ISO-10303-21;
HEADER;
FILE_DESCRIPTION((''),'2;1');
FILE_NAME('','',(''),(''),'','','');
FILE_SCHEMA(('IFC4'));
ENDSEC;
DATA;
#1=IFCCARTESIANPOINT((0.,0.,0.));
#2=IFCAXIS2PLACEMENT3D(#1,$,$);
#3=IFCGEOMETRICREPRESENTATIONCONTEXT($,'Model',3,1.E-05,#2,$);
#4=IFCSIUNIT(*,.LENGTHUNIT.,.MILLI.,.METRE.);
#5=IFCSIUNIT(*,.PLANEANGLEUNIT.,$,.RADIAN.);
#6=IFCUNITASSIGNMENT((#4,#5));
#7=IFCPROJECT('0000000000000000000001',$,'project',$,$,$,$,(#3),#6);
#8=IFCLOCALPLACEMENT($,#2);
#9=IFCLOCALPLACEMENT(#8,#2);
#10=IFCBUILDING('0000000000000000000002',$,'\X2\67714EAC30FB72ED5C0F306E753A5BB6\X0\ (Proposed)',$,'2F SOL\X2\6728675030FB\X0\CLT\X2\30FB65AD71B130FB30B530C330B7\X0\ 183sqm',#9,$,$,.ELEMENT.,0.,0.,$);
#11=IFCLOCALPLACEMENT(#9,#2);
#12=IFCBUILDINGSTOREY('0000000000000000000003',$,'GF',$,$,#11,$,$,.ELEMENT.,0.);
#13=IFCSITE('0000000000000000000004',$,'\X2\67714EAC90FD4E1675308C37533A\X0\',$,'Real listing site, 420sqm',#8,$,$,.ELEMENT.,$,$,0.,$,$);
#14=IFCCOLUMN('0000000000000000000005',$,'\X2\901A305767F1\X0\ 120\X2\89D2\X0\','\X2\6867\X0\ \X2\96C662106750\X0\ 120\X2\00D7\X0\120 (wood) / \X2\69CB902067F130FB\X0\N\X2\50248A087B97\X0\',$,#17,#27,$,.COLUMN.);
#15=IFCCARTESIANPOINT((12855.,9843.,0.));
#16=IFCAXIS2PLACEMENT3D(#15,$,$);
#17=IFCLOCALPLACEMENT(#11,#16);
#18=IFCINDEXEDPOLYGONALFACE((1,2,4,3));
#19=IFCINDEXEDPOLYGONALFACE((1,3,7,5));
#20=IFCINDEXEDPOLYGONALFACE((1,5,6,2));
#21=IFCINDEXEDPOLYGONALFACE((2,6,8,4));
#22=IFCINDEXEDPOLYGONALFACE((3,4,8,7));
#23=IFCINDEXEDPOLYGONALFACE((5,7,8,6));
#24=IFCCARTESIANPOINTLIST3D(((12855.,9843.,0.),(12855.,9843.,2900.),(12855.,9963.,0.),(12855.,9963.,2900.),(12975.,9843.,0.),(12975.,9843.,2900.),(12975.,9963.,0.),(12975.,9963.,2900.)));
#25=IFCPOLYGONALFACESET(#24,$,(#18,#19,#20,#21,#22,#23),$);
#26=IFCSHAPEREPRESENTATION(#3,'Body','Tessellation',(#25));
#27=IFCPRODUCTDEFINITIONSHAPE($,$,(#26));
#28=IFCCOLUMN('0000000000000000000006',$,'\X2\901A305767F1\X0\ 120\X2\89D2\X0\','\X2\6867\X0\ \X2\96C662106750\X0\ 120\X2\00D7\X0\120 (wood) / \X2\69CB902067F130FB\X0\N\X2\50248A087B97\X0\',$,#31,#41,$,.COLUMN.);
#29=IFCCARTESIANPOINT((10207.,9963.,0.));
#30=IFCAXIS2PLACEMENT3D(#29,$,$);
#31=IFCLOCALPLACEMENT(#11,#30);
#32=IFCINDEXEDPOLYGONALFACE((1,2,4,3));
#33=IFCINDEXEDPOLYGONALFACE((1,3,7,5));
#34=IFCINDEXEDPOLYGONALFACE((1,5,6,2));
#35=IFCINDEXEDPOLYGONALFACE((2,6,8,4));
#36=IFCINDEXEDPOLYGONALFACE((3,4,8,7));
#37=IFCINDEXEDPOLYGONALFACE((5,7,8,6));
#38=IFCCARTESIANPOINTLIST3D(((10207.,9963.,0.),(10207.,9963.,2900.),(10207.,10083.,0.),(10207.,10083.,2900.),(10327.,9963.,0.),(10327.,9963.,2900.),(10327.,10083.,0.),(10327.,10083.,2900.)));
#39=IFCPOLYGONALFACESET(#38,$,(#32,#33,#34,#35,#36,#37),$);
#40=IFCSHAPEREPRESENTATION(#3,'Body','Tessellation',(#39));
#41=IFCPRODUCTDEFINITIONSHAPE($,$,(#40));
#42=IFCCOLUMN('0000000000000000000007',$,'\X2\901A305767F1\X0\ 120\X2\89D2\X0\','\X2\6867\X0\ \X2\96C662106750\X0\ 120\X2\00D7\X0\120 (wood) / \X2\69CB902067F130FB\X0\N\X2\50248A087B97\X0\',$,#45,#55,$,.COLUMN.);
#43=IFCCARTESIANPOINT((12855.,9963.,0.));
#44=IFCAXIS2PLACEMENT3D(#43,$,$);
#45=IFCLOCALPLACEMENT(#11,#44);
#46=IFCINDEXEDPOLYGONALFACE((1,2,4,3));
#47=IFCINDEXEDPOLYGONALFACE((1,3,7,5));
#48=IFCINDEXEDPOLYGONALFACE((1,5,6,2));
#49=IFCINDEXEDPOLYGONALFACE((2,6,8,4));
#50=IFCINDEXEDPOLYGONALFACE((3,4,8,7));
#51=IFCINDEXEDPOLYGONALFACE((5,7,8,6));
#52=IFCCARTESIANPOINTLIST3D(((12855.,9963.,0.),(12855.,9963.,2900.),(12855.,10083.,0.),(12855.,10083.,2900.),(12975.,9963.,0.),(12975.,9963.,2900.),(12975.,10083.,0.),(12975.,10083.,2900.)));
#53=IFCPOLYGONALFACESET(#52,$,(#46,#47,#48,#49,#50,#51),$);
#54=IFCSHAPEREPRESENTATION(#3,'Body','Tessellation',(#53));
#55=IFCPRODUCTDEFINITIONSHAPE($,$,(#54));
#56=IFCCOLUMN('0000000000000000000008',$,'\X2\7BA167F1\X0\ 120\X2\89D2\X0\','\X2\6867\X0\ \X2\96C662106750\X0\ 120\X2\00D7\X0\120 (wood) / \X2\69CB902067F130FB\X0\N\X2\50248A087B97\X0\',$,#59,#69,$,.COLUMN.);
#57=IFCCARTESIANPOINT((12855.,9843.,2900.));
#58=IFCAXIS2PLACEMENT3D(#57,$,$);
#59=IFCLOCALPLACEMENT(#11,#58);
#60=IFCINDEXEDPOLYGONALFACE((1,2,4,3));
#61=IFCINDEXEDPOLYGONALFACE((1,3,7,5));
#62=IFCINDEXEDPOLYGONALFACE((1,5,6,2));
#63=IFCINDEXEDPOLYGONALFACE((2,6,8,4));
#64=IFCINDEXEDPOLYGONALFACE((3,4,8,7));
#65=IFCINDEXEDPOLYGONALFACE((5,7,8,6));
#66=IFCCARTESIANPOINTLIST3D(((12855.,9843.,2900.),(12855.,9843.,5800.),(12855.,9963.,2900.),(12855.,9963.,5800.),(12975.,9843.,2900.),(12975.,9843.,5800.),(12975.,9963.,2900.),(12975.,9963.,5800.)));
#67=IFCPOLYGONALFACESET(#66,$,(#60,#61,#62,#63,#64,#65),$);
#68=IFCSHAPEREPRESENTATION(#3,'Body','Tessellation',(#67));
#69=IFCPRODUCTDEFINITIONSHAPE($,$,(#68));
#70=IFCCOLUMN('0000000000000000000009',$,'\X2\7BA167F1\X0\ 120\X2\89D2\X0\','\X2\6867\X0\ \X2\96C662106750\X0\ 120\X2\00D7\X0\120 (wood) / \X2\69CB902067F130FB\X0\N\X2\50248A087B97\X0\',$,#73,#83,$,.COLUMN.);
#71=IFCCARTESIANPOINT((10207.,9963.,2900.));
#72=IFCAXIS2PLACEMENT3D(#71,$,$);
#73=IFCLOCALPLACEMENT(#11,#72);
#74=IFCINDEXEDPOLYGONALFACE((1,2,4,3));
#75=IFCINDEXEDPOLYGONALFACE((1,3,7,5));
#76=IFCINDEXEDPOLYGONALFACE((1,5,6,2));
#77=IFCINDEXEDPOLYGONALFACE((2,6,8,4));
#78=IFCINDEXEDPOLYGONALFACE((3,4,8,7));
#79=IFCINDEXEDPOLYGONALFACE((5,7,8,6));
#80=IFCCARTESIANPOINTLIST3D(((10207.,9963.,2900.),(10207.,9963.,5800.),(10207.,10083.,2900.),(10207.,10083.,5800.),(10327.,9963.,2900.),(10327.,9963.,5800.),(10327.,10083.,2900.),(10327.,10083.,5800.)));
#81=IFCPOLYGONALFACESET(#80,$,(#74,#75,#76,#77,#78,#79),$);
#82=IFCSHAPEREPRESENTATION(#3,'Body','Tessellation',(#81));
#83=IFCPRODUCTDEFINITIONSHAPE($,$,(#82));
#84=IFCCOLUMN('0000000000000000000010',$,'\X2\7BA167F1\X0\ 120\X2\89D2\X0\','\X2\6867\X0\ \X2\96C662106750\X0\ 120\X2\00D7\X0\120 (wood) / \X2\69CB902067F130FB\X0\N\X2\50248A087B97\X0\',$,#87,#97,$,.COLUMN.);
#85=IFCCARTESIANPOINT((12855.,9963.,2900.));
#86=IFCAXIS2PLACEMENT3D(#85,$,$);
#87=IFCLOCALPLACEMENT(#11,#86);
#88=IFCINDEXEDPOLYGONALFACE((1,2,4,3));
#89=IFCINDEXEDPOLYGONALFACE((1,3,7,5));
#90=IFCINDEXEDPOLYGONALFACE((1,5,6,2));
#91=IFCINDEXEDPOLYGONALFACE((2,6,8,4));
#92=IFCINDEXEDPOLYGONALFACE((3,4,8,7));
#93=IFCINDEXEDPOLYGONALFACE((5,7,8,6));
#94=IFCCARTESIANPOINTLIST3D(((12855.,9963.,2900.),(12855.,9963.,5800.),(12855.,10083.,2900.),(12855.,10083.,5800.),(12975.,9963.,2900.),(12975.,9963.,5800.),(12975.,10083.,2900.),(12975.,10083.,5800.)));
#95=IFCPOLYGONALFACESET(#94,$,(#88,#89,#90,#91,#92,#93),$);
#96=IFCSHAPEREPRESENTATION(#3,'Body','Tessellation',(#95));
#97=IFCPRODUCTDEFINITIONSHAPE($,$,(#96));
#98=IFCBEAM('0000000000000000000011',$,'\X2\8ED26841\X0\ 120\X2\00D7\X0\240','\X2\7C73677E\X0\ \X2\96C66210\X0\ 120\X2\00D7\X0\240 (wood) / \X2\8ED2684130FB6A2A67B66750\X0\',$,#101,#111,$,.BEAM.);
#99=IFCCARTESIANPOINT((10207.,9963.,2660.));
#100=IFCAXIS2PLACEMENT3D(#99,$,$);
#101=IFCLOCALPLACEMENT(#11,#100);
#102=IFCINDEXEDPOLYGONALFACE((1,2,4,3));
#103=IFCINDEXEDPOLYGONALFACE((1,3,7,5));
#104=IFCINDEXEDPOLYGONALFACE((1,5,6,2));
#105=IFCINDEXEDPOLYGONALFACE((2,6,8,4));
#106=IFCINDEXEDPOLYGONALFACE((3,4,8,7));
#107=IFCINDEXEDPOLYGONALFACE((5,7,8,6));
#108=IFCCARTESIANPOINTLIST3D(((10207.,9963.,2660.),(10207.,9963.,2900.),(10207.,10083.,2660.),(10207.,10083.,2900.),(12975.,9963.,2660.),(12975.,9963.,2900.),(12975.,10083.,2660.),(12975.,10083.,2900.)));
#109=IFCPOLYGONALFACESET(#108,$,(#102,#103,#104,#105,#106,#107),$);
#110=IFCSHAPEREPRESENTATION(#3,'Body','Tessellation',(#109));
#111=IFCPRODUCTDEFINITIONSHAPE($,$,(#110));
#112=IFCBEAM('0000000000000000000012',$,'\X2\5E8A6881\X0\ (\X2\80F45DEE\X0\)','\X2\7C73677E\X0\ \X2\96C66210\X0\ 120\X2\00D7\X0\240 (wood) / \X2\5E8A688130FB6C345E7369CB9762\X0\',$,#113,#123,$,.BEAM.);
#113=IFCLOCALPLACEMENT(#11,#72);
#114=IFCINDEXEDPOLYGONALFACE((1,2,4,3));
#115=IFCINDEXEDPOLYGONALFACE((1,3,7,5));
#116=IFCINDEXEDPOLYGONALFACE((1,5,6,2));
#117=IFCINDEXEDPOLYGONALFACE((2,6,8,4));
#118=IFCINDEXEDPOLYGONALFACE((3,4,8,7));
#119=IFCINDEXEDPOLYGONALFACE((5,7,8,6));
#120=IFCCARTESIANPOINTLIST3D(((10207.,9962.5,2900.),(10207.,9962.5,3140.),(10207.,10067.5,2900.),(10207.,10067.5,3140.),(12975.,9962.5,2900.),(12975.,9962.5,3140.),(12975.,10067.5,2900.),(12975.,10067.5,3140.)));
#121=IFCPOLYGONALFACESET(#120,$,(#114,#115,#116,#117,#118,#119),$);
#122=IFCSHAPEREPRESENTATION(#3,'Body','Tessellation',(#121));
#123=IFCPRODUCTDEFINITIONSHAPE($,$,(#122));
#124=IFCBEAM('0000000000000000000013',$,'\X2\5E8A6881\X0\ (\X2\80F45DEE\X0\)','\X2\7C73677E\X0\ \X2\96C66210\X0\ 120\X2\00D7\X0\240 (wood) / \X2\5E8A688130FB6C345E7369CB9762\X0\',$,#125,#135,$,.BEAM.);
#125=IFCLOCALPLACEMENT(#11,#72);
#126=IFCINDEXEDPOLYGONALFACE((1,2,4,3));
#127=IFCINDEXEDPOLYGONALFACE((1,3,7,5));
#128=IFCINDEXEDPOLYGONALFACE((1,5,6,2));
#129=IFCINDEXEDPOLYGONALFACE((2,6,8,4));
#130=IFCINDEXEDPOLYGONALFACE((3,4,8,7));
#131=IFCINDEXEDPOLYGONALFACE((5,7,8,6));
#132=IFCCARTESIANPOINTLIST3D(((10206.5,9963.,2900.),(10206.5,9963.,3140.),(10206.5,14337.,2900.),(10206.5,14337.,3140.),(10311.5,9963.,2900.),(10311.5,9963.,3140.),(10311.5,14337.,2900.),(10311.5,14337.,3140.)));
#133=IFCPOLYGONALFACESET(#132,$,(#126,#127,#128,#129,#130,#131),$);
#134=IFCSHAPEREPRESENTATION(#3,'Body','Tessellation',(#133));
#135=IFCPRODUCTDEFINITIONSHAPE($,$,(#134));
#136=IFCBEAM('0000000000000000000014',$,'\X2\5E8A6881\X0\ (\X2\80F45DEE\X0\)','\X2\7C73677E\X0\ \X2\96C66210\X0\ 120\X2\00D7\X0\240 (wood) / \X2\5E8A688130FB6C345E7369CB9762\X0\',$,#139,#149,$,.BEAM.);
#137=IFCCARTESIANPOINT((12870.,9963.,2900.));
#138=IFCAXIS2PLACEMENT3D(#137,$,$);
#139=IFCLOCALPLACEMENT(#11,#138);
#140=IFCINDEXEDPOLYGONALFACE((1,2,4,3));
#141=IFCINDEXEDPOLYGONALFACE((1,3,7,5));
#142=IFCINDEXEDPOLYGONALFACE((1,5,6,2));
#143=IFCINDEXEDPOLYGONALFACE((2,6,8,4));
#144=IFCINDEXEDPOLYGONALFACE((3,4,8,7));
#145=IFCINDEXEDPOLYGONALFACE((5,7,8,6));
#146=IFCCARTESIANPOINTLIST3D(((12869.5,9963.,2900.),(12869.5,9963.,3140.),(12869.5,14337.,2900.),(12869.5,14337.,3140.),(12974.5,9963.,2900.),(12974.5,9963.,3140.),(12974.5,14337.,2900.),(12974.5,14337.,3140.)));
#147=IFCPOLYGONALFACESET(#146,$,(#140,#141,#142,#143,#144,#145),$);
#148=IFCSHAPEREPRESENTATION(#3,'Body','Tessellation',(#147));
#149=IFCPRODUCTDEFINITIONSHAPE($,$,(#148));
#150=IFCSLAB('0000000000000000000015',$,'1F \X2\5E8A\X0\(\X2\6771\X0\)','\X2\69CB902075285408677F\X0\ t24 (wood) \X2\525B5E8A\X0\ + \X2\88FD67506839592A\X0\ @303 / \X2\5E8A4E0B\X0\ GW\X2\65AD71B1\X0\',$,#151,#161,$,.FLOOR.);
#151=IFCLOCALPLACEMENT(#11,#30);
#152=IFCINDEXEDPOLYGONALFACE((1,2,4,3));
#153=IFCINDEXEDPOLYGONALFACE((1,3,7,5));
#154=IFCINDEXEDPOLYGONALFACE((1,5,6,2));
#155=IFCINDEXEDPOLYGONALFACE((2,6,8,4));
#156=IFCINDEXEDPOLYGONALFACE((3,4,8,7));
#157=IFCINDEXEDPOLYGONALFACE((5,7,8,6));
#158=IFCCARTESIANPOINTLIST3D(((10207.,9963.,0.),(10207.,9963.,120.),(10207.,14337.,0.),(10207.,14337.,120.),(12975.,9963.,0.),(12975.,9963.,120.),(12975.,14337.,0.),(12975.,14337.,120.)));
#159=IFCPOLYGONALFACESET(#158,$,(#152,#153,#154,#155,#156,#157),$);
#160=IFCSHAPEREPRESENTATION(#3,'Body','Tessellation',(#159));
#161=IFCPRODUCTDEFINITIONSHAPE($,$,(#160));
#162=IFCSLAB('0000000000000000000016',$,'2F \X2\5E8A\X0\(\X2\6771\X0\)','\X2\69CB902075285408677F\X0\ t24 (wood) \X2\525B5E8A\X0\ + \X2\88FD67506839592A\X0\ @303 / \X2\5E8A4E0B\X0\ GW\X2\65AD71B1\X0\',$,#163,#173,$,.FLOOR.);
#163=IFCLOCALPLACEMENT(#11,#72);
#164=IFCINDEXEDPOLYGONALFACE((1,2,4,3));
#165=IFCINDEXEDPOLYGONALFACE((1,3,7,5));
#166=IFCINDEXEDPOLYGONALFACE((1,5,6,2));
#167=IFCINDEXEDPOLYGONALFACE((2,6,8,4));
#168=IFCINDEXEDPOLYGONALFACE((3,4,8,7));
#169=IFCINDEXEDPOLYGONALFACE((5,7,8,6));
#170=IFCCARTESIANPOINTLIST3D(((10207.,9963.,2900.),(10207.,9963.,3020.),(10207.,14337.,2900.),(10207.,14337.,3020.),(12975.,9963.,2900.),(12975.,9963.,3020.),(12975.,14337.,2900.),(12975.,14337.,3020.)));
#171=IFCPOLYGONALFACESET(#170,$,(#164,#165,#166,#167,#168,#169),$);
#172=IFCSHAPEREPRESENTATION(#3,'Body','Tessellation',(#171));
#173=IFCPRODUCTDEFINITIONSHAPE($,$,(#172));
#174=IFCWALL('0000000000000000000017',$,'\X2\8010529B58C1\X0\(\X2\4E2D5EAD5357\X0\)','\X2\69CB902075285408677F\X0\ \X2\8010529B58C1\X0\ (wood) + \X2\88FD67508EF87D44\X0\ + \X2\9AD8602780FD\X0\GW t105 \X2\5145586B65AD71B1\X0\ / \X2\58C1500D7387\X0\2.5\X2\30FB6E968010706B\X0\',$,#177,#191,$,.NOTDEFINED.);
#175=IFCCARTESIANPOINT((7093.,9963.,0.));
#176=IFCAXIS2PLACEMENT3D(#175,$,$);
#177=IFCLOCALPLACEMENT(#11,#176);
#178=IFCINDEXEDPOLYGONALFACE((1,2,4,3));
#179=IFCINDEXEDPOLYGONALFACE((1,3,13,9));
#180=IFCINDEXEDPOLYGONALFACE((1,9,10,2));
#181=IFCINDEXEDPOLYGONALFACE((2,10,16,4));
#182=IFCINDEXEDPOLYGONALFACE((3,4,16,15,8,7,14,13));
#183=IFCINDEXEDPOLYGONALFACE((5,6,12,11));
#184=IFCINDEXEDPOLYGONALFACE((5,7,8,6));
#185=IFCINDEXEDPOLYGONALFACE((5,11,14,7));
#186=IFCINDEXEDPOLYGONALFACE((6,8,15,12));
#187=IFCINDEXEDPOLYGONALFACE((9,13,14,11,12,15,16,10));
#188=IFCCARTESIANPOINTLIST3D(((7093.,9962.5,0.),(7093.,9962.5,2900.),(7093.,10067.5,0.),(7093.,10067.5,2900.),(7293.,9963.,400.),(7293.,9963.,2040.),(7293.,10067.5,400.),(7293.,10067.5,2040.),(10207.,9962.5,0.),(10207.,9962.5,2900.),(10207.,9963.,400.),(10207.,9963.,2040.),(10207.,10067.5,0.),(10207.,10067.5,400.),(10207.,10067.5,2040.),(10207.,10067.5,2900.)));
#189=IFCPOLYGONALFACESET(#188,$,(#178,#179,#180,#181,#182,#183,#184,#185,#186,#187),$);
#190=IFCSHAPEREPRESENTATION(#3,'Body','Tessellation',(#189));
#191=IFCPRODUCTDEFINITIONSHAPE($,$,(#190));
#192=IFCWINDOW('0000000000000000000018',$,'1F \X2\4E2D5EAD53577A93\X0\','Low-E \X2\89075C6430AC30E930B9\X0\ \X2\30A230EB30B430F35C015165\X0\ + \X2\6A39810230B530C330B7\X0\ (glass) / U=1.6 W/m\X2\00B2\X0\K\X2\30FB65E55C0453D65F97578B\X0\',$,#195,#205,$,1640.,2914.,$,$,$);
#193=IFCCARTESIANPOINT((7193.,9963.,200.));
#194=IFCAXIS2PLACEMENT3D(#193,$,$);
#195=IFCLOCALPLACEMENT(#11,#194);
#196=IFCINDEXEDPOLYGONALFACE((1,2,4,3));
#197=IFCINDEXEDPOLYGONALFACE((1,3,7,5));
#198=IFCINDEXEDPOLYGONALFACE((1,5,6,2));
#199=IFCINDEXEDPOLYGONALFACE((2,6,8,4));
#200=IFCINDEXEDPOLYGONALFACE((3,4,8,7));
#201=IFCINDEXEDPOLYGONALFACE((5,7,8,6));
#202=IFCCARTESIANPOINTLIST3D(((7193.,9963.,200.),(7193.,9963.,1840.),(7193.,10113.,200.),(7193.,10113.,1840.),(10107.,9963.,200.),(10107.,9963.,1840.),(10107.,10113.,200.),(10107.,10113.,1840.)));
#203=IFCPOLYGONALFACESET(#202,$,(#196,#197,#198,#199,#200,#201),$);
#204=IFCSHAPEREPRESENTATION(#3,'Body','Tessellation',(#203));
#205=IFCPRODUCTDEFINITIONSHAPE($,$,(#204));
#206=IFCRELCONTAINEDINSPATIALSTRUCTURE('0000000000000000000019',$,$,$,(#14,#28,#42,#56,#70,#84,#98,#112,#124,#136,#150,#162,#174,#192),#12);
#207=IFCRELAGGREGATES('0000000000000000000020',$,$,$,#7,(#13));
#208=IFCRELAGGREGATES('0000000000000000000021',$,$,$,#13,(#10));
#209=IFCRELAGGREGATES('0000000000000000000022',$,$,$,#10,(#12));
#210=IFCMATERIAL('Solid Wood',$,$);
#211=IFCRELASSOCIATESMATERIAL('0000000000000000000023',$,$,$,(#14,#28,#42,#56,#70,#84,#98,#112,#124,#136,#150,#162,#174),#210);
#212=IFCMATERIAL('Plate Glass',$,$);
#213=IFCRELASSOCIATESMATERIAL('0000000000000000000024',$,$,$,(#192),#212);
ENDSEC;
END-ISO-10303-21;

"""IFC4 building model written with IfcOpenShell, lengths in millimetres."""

from ifc_helpers import new_model, si_unit, frame, frame_2d, origin, place, context, project, spatial, rectangle, extrude, material, element, fill, save


model = new_model("IFC4")

# Units and contexts
model_context = context("Model", 3, precision=1e-05, world=origin())
ifc_project = project(units=[si_unit("LENGTHUNIT", "METRE", prefix="MILLI"), si_unit("PLANEANGLEUNIT", "RADIAN")], contexts=[model_context])

# Site, building, storey
site_placement = place(None, origin())
site = spatial("IfcSite", under=ifc_project, at=site_placement, Name="東京都世田谷区", ObjectType="Real listing site, 420sqm", CompositionType="ELEMENT", RefElevation=0.0)
building_placement = place(site_placement, origin())
building = spatial("IfcBuilding", under=site, at=building_placement, Name="東京・狭小の町家 (Proposed)", ObjectType="2F SOL木材・CLT・断熱・サッシ 183sqm", CompositionType="ELEMENT", ElevationOfRefHeight=0.0, ElevationOfTerrain=0.0)
storey_placement = place(building_placement, origin())
storey = spatial("IfcBuildingStorey", under=building, at=storey_placement, Name="GF", CompositionType="ELEMENT", Elevation=0.0)

# Columns
ifc_material_1 = material(Name="Solid Wood")
column_1_placement = place(storey_placement, frame((12855.0, 9843.0, 0.0)))
element("IfcColumn", 1, at=column_1_placement, inside=storey, material=ifc_material_1, Name="通し柱 120角", Description="桧 集成材 120×120 (wood) / 構造柱・N値計算", PredefinedType="COLUMN", context=model_context, shape_type="SweptSolid", body=[
    extrude(rectangle(XDim=120.0, YDim=120.0, at=frame_2d((60.0, 60.0))), frame((12855.0, 9843.0, 0.0)), (0.0, 0.0, 1.0), 2900.0),
])
column_2_placement = place(storey_placement, frame((10207.0, 9963.0, 0.0)))
element("IfcColumn", 2, at=column_2_placement, inside=storey, material=ifc_material_1, Name="通し柱 120角", Description="桧 集成材 120×120 (wood) / 構造柱・N値計算", PredefinedType="COLUMN", context=model_context, shape_type="SweptSolid", body=[
    extrude(rectangle(XDim=120.0, YDim=120.0, at=frame_2d((60.0, 60.0))), frame((10207.0, 9963.0, 0.0)), (0.0, 0.0, 1.0), 2900.0),
])
column_3_placement = place(storey_placement, frame((12855.0, 9963.0, 0.0)))
element("IfcColumn", 3, at=column_3_placement, inside=storey, material=ifc_material_1, Name="通し柱 120角", Description="桧 集成材 120×120 (wood) / 構造柱・N値計算", PredefinedType="COLUMN", context=model_context, shape_type="SweptSolid", body=[
    extrude(rectangle(XDim=120.0, YDim=120.0, at=frame_2d((60.0, 60.0))), frame((12855.0, 9963.0, 0.0)), (0.0, 0.0, 1.0), 2900.0),
])
column_4_placement = place(storey_placement, frame((12855.0, 9843.0, 2900.0)))
element("IfcColumn", 4, at=column_4_placement, inside=storey, material=ifc_material_1, Name="管柱 120角", Description="桧 集成材 120×120 (wood) / 構造柱・N値計算", PredefinedType="COLUMN", context=model_context, shape_type="SweptSolid", body=[
    extrude(rectangle(XDim=120.0, YDim=120.0, at=frame_2d((60.0, 60.0))), frame((12855.0, 9843.0, 2900.0)), (0.0, 0.0, 1.0), 2900.0),
])
column_5_placement = place(storey_placement, frame((10207.0, 9963.0, 2900.0)))
element("IfcColumn", 5, at=column_5_placement, inside=storey, material=ifc_material_1, Name="管柱 120角", Description="桧 集成材 120×120 (wood) / 構造柱・N値計算", PredefinedType="COLUMN", context=model_context, shape_type="SweptSolid", body=[
    extrude(rectangle(XDim=120.0, YDim=120.0, at=frame_2d((60.0, 60.0))), frame((10207.0, 9963.0, 2900.0)), (0.0, 0.0, 1.0), 2900.0),
])
column_6_placement = place(storey_placement, frame((12855.0, 9963.0, 2900.0)))
element("IfcColumn", 6, at=column_6_placement, inside=storey, material=ifc_material_1, Name="管柱 120角", Description="桧 集成材 120×120 (wood) / 構造柱・N値計算", PredefinedType="COLUMN", context=model_context, shape_type="SweptSolid", body=[
    extrude(rectangle(XDim=120.0, YDim=120.0, at=frame_2d((60.0, 60.0))), frame((12855.0, 9963.0, 2900.0)), (0.0, 0.0, 1.0), 2900.0),
])

# Beams
beam_1_placement = place(storey_placement, frame((10207.0, 9963.0, 2660.0)))
element("IfcBeam", 7, at=beam_1_placement, inside=storey, material=ifc_material_1, Name="軒桁 120×240", Description="米松 集成 120×240 (wood) / 軒桁・横架材", PredefinedType="BEAM", context=model_context, shape_type="SweptSolid", body=[
    extrude(rectangle(XDim=2768.0, YDim=120.0, at=frame_2d((1384.0, 60.0))), frame((10207.0, 9963.0, 2660.0)), (0.0, 0.0, 1.0), 240.0),
])
beam_2_placement = place(storey_placement, frame((10207.0, 9963.0, 2900.0)))
element("IfcBeam", 8, at=beam_2_placement, inside=storey, material=ifc_material_1, Name="床梁 (胴差)", Description="米松 集成 120×240 (wood) / 床梁・水平構面", PredefinedType="BEAM", context=model_context, shape_type="SweptSolid", body=[
    extrude(rectangle(XDim=2768.0, YDim=105.0, at=frame_2d((1384.0, 52.0))), frame((10207.0, 9963.0, 2900.0)), (0.0, 0.0, 1.0), 240.0),
])
beam_3_placement = place(storey_placement, frame((10207.0, 9963.0, 2900.0)))
element("IfcBeam", 9, at=beam_3_placement, inside=storey, material=ifc_material_1, Name="床梁 (胴差)", Description="米松 集成 120×240 (wood) / 床梁・水平構面", PredefinedType="BEAM", context=model_context, shape_type="SweptSolid", body=[
    extrude(rectangle(XDim=105.0, YDim=4374.0, at=frame_2d((52.0, 2187.0))), frame((10207.0, 9963.0, 2900.0)), (0.0, 0.0, 1.0), 240.0),
])
beam_4_placement = place(storey_placement, frame((12870.0, 9963.0, 2900.0)))
element("IfcBeam", 10, at=beam_4_placement, inside=storey, material=ifc_material_1, Name="床梁 (胴差)", Description="米松 集成 120×240 (wood) / 床梁・水平構面", PredefinedType="BEAM", context=model_context, shape_type="SweptSolid", body=[
    extrude(rectangle(XDim=105.0, YDim=4374.0, at=frame_2d((52.0, 2187.0))), frame((12870.0, 9963.0, 2900.0)), (0.0, 0.0, 1.0), 240.0),
])

# Slabs
slab_1_placement = place(storey_placement, frame((10207.0, 9963.0, 0.0)))
element("IfcSlab", 11, at=slab_1_placement, inside=storey, material=ifc_material_1, Name="1F 床(東)", Description="構造用合板 t24 (wood) 剛床 + 製材根太 @303 / 床下 GW断熱", PredefinedType="FLOOR", context=model_context, shape_type="SweptSolid", body=[
    extrude(rectangle(XDim=2768.0, YDim=4374.0, at=frame_2d((1384.0, 2187.0))), frame((10207.0, 9963.0, 0.0)), (0.0, 0.0, 1.0), 120.0),
])
slab_2_placement = place(storey_placement, frame((10207.0, 9963.0, 2900.0)))
element("IfcSlab", 12, at=slab_2_placement, inside=storey, material=ifc_material_1, Name="2F 床(東)", Description="構造用合板 t24 (wood) 剛床 + 製材根太 @303 / 床下 GW断熱", PredefinedType="FLOOR", context=model_context, shape_type="SweptSolid", body=[
    extrude(rectangle(XDim=2768.0, YDim=4374.0, at=frame_2d((1384.0, 2187.0))), frame((10207.0, 9963.0, 2900.0)), (0.0, 0.0, 1.0), 120.0),
])

# Wall, opening, window
wall_1_placement = place(storey_placement, frame((7093.0, 9963.0, 0.0)))
wall_1 = element("IfcWall", 13, at=wall_1_placement, inside=storey, material=ifc_material_1, Name="耐力壁(中庭南)", Description="構造用合板 耐力壁 (wood) + 製材軸組 + 高性能GW t105 充填断熱 / 壁倍率2.5・準耐火", PredefinedType="NOTDEFINED", context=model_context, shape_type="SweptSolid", body=[
    extrude(rectangle(XDim=3114.0, YDim=105.0, at=frame_2d((1557.0, 52.0))), frame((7093.0, 9963.0, 0.0)), (0.0, 0.0, 1.0), 2900.0),
])
opening_1_placement = place(storey_placement, frame((7193.0, 9963.0, 200.0)))
opening_1 = element("IfcOpeningElement", 14, at=opening_1_placement, cuts=wall_1, PredefinedType="NOTDEFINED", context=model_context, shape_type="SweptSolid", body=[
    extrude(rectangle(XDim=2914.0, YDim=150.0, at=frame_2d((1457.0, 75.0))), frame((7193.0, 9963.0, 200.0)), (0.0, 0.0, 1.0), 1640.0),
])
ifc_material_2 = material(Name="Plate Glass")
window_1_placement = place(storey_placement, frame((7193.0, 9963.0, 200.0)))
window_1 = element("IfcWindow", 15, at=window_1_placement, inside=storey, material=ifc_material_2, Name="1F 中庭南窓", Description="Low-E 複層ガラス アルゴン封入 + 樹脂サッシ (glass) / U=1.6 W/m²K・日射取得型", OverallHeight=1640.0, OverallWidth=2914.0, context=model_context, shape_type="SweptSolid", body=[
    extrude(rectangle(XDim=2914.0, YDim=150.0, at=frame_2d((1457.0, 75.0))), frame((7193.0, 9963.0, 200.0)), (0.0, 0.0, 1.0), 1640.0),
])
fill(opening_1, window_1)

save(model, "model.ifc")
